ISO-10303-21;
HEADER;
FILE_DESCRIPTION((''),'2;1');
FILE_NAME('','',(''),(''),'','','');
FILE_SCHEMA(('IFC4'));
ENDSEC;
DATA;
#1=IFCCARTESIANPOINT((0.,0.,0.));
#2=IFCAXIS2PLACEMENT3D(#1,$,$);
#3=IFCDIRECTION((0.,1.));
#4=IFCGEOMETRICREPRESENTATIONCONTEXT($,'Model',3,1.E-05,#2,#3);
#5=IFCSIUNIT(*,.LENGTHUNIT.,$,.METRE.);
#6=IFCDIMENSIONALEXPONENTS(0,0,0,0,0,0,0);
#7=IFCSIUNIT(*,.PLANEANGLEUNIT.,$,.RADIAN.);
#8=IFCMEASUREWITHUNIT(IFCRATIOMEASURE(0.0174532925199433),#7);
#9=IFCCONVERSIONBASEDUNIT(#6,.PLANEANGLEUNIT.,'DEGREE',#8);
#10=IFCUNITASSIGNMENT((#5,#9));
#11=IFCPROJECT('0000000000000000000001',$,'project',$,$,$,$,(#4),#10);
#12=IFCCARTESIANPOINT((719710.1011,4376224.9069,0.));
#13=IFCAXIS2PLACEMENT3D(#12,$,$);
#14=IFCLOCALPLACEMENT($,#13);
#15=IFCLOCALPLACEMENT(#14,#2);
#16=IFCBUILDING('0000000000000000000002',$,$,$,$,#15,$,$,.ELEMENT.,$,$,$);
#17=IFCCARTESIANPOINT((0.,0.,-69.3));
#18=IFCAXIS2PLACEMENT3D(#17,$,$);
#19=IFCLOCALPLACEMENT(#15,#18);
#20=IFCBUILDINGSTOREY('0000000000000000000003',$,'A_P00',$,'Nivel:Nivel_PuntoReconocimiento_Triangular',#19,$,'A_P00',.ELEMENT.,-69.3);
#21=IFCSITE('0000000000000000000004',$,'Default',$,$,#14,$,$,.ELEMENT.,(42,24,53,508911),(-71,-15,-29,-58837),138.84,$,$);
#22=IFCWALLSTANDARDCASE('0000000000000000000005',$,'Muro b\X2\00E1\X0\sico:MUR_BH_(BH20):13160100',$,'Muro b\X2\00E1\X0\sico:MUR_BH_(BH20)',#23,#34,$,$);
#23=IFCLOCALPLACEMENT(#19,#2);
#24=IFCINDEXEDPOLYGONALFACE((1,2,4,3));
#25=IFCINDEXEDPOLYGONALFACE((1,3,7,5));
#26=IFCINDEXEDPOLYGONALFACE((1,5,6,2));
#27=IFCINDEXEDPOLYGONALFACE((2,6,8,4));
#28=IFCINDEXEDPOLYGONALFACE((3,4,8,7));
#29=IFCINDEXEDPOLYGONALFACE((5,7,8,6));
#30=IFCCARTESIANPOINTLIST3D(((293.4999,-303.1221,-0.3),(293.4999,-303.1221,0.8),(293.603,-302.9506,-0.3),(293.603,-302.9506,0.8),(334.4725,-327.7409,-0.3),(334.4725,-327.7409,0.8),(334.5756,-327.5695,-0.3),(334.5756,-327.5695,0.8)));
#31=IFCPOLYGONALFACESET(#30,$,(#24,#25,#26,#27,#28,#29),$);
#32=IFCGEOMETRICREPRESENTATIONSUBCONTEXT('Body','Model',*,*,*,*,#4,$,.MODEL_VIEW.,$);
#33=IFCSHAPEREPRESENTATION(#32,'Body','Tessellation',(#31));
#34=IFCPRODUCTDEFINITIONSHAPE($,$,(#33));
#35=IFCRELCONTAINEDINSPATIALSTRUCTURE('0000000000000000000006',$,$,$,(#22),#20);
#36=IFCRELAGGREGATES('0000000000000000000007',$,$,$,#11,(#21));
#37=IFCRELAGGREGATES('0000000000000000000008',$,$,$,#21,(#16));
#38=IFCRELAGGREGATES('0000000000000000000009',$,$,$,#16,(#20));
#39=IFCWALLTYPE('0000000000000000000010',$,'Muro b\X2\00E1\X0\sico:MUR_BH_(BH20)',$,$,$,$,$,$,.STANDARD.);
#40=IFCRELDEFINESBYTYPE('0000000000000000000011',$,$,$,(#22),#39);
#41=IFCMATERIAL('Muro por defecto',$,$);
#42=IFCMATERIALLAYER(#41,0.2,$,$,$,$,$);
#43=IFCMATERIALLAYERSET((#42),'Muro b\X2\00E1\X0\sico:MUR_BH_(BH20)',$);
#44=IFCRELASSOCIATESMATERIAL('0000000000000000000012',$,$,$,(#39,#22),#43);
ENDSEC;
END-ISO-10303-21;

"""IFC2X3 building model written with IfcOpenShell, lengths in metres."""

from ifc_helpers import new_model, entity, si_unit, converted_unit, direction, frame, frame_2d, origin, place, context, subcontext, project, spatial, rectangle, extrude, material, layer, layer_set, layer_usage, type_object, element, save


model = new_model("IFC2X3")

# Units and contexts
model_context = context("Model", 3, precision=1e-05, world=origin(), true_north=direction((0.0, 1.0)))
body_context = subcontext(model_context, "Body", "Model", "MODEL_VIEW")
ifc_project = project(units=[si_unit("LENGTHUNIT", "METRE"), converted_unit("PLANEANGLEUNIT", "DEGREE", entity("IfcRatioMeasure", 0.0174532925199433), si_unit("PLANEANGLEUNIT", "RADIAN"), dimensions=[0, 0, 0, 0, 0, 0, 0])], contexts=[model_context])

# Site, building, storey
site_placement = place(None, frame((719710.1011, 4376224.9069, 0.0)))
site = spatial("IfcSite", under=ifc_project, at=site_placement, Name="Default", CompositionType="ELEMENT", RefLatitude=(42, 24, 53, 508911), RefLongitude=(-71, -15, -29, -58837), RefElevation=138.84)
building_placement = place(site_placement, origin())
building = spatial("IfcBuilding", under=site, at=building_placement, CompositionType="ELEMENT")
storey_placement = place(building_placement, frame((0.0, 0.0, -69.3)))
storey = spatial("IfcBuildingStorey", under=building, at=storey_placement, Name="A_P00", ObjectType="Nivel:Nivel_PuntoReconocimiento_Triangular", LongName="A_P00", CompositionType="ELEMENT", Elevation=-69.3)

# Shared definitions
ifc_material_1 = material(Name="Muro por defecto")
ifc_layer_1 = layer(ifc_material_1, 0.2)
ifc_layer_set_1 = layer_set([ifc_layer_1], Name="Muro básico:MUR_BH_(BH20)")
wall_type = type_object("IfcWallType", Name="Muro básico:MUR_BH_(BH20)", PredefinedType="STANDARD", material=ifc_layer_set_1)

# Wall
ifc_layer_usage_1 = layer_usage(ifc_layer_set_1, "AXIS2", "NEGATIVE", 0.1)
wall_1_placement = place(storey_placement, frame((334.5241, -327.6552, -0.3), z_axis=(0.0, 0.0, 1.0), x_axis=(-0.857167, 0.515038, 0.0)))
element("IfcWallStandardCase", 1, at=wall_1_placement, inside=storey, type_object=wall_type, material=ifc_layer_usage_1, Name="Muro básico:MUR_BH_(BH20):13160100", ObjectType="Muro básico:MUR_BH_(BH20)", context=body_context, shape_type="SweptSolid", body=[
    extrude(rectangle(XDim=47.8, YDim=0.2, at=frame_2d((23.9, 0.0), x_axis=(-1.0, 0.0))), origin(), (0.0, 0.0, 1.0), 1.1),
])

save(model, "model.ifc")
